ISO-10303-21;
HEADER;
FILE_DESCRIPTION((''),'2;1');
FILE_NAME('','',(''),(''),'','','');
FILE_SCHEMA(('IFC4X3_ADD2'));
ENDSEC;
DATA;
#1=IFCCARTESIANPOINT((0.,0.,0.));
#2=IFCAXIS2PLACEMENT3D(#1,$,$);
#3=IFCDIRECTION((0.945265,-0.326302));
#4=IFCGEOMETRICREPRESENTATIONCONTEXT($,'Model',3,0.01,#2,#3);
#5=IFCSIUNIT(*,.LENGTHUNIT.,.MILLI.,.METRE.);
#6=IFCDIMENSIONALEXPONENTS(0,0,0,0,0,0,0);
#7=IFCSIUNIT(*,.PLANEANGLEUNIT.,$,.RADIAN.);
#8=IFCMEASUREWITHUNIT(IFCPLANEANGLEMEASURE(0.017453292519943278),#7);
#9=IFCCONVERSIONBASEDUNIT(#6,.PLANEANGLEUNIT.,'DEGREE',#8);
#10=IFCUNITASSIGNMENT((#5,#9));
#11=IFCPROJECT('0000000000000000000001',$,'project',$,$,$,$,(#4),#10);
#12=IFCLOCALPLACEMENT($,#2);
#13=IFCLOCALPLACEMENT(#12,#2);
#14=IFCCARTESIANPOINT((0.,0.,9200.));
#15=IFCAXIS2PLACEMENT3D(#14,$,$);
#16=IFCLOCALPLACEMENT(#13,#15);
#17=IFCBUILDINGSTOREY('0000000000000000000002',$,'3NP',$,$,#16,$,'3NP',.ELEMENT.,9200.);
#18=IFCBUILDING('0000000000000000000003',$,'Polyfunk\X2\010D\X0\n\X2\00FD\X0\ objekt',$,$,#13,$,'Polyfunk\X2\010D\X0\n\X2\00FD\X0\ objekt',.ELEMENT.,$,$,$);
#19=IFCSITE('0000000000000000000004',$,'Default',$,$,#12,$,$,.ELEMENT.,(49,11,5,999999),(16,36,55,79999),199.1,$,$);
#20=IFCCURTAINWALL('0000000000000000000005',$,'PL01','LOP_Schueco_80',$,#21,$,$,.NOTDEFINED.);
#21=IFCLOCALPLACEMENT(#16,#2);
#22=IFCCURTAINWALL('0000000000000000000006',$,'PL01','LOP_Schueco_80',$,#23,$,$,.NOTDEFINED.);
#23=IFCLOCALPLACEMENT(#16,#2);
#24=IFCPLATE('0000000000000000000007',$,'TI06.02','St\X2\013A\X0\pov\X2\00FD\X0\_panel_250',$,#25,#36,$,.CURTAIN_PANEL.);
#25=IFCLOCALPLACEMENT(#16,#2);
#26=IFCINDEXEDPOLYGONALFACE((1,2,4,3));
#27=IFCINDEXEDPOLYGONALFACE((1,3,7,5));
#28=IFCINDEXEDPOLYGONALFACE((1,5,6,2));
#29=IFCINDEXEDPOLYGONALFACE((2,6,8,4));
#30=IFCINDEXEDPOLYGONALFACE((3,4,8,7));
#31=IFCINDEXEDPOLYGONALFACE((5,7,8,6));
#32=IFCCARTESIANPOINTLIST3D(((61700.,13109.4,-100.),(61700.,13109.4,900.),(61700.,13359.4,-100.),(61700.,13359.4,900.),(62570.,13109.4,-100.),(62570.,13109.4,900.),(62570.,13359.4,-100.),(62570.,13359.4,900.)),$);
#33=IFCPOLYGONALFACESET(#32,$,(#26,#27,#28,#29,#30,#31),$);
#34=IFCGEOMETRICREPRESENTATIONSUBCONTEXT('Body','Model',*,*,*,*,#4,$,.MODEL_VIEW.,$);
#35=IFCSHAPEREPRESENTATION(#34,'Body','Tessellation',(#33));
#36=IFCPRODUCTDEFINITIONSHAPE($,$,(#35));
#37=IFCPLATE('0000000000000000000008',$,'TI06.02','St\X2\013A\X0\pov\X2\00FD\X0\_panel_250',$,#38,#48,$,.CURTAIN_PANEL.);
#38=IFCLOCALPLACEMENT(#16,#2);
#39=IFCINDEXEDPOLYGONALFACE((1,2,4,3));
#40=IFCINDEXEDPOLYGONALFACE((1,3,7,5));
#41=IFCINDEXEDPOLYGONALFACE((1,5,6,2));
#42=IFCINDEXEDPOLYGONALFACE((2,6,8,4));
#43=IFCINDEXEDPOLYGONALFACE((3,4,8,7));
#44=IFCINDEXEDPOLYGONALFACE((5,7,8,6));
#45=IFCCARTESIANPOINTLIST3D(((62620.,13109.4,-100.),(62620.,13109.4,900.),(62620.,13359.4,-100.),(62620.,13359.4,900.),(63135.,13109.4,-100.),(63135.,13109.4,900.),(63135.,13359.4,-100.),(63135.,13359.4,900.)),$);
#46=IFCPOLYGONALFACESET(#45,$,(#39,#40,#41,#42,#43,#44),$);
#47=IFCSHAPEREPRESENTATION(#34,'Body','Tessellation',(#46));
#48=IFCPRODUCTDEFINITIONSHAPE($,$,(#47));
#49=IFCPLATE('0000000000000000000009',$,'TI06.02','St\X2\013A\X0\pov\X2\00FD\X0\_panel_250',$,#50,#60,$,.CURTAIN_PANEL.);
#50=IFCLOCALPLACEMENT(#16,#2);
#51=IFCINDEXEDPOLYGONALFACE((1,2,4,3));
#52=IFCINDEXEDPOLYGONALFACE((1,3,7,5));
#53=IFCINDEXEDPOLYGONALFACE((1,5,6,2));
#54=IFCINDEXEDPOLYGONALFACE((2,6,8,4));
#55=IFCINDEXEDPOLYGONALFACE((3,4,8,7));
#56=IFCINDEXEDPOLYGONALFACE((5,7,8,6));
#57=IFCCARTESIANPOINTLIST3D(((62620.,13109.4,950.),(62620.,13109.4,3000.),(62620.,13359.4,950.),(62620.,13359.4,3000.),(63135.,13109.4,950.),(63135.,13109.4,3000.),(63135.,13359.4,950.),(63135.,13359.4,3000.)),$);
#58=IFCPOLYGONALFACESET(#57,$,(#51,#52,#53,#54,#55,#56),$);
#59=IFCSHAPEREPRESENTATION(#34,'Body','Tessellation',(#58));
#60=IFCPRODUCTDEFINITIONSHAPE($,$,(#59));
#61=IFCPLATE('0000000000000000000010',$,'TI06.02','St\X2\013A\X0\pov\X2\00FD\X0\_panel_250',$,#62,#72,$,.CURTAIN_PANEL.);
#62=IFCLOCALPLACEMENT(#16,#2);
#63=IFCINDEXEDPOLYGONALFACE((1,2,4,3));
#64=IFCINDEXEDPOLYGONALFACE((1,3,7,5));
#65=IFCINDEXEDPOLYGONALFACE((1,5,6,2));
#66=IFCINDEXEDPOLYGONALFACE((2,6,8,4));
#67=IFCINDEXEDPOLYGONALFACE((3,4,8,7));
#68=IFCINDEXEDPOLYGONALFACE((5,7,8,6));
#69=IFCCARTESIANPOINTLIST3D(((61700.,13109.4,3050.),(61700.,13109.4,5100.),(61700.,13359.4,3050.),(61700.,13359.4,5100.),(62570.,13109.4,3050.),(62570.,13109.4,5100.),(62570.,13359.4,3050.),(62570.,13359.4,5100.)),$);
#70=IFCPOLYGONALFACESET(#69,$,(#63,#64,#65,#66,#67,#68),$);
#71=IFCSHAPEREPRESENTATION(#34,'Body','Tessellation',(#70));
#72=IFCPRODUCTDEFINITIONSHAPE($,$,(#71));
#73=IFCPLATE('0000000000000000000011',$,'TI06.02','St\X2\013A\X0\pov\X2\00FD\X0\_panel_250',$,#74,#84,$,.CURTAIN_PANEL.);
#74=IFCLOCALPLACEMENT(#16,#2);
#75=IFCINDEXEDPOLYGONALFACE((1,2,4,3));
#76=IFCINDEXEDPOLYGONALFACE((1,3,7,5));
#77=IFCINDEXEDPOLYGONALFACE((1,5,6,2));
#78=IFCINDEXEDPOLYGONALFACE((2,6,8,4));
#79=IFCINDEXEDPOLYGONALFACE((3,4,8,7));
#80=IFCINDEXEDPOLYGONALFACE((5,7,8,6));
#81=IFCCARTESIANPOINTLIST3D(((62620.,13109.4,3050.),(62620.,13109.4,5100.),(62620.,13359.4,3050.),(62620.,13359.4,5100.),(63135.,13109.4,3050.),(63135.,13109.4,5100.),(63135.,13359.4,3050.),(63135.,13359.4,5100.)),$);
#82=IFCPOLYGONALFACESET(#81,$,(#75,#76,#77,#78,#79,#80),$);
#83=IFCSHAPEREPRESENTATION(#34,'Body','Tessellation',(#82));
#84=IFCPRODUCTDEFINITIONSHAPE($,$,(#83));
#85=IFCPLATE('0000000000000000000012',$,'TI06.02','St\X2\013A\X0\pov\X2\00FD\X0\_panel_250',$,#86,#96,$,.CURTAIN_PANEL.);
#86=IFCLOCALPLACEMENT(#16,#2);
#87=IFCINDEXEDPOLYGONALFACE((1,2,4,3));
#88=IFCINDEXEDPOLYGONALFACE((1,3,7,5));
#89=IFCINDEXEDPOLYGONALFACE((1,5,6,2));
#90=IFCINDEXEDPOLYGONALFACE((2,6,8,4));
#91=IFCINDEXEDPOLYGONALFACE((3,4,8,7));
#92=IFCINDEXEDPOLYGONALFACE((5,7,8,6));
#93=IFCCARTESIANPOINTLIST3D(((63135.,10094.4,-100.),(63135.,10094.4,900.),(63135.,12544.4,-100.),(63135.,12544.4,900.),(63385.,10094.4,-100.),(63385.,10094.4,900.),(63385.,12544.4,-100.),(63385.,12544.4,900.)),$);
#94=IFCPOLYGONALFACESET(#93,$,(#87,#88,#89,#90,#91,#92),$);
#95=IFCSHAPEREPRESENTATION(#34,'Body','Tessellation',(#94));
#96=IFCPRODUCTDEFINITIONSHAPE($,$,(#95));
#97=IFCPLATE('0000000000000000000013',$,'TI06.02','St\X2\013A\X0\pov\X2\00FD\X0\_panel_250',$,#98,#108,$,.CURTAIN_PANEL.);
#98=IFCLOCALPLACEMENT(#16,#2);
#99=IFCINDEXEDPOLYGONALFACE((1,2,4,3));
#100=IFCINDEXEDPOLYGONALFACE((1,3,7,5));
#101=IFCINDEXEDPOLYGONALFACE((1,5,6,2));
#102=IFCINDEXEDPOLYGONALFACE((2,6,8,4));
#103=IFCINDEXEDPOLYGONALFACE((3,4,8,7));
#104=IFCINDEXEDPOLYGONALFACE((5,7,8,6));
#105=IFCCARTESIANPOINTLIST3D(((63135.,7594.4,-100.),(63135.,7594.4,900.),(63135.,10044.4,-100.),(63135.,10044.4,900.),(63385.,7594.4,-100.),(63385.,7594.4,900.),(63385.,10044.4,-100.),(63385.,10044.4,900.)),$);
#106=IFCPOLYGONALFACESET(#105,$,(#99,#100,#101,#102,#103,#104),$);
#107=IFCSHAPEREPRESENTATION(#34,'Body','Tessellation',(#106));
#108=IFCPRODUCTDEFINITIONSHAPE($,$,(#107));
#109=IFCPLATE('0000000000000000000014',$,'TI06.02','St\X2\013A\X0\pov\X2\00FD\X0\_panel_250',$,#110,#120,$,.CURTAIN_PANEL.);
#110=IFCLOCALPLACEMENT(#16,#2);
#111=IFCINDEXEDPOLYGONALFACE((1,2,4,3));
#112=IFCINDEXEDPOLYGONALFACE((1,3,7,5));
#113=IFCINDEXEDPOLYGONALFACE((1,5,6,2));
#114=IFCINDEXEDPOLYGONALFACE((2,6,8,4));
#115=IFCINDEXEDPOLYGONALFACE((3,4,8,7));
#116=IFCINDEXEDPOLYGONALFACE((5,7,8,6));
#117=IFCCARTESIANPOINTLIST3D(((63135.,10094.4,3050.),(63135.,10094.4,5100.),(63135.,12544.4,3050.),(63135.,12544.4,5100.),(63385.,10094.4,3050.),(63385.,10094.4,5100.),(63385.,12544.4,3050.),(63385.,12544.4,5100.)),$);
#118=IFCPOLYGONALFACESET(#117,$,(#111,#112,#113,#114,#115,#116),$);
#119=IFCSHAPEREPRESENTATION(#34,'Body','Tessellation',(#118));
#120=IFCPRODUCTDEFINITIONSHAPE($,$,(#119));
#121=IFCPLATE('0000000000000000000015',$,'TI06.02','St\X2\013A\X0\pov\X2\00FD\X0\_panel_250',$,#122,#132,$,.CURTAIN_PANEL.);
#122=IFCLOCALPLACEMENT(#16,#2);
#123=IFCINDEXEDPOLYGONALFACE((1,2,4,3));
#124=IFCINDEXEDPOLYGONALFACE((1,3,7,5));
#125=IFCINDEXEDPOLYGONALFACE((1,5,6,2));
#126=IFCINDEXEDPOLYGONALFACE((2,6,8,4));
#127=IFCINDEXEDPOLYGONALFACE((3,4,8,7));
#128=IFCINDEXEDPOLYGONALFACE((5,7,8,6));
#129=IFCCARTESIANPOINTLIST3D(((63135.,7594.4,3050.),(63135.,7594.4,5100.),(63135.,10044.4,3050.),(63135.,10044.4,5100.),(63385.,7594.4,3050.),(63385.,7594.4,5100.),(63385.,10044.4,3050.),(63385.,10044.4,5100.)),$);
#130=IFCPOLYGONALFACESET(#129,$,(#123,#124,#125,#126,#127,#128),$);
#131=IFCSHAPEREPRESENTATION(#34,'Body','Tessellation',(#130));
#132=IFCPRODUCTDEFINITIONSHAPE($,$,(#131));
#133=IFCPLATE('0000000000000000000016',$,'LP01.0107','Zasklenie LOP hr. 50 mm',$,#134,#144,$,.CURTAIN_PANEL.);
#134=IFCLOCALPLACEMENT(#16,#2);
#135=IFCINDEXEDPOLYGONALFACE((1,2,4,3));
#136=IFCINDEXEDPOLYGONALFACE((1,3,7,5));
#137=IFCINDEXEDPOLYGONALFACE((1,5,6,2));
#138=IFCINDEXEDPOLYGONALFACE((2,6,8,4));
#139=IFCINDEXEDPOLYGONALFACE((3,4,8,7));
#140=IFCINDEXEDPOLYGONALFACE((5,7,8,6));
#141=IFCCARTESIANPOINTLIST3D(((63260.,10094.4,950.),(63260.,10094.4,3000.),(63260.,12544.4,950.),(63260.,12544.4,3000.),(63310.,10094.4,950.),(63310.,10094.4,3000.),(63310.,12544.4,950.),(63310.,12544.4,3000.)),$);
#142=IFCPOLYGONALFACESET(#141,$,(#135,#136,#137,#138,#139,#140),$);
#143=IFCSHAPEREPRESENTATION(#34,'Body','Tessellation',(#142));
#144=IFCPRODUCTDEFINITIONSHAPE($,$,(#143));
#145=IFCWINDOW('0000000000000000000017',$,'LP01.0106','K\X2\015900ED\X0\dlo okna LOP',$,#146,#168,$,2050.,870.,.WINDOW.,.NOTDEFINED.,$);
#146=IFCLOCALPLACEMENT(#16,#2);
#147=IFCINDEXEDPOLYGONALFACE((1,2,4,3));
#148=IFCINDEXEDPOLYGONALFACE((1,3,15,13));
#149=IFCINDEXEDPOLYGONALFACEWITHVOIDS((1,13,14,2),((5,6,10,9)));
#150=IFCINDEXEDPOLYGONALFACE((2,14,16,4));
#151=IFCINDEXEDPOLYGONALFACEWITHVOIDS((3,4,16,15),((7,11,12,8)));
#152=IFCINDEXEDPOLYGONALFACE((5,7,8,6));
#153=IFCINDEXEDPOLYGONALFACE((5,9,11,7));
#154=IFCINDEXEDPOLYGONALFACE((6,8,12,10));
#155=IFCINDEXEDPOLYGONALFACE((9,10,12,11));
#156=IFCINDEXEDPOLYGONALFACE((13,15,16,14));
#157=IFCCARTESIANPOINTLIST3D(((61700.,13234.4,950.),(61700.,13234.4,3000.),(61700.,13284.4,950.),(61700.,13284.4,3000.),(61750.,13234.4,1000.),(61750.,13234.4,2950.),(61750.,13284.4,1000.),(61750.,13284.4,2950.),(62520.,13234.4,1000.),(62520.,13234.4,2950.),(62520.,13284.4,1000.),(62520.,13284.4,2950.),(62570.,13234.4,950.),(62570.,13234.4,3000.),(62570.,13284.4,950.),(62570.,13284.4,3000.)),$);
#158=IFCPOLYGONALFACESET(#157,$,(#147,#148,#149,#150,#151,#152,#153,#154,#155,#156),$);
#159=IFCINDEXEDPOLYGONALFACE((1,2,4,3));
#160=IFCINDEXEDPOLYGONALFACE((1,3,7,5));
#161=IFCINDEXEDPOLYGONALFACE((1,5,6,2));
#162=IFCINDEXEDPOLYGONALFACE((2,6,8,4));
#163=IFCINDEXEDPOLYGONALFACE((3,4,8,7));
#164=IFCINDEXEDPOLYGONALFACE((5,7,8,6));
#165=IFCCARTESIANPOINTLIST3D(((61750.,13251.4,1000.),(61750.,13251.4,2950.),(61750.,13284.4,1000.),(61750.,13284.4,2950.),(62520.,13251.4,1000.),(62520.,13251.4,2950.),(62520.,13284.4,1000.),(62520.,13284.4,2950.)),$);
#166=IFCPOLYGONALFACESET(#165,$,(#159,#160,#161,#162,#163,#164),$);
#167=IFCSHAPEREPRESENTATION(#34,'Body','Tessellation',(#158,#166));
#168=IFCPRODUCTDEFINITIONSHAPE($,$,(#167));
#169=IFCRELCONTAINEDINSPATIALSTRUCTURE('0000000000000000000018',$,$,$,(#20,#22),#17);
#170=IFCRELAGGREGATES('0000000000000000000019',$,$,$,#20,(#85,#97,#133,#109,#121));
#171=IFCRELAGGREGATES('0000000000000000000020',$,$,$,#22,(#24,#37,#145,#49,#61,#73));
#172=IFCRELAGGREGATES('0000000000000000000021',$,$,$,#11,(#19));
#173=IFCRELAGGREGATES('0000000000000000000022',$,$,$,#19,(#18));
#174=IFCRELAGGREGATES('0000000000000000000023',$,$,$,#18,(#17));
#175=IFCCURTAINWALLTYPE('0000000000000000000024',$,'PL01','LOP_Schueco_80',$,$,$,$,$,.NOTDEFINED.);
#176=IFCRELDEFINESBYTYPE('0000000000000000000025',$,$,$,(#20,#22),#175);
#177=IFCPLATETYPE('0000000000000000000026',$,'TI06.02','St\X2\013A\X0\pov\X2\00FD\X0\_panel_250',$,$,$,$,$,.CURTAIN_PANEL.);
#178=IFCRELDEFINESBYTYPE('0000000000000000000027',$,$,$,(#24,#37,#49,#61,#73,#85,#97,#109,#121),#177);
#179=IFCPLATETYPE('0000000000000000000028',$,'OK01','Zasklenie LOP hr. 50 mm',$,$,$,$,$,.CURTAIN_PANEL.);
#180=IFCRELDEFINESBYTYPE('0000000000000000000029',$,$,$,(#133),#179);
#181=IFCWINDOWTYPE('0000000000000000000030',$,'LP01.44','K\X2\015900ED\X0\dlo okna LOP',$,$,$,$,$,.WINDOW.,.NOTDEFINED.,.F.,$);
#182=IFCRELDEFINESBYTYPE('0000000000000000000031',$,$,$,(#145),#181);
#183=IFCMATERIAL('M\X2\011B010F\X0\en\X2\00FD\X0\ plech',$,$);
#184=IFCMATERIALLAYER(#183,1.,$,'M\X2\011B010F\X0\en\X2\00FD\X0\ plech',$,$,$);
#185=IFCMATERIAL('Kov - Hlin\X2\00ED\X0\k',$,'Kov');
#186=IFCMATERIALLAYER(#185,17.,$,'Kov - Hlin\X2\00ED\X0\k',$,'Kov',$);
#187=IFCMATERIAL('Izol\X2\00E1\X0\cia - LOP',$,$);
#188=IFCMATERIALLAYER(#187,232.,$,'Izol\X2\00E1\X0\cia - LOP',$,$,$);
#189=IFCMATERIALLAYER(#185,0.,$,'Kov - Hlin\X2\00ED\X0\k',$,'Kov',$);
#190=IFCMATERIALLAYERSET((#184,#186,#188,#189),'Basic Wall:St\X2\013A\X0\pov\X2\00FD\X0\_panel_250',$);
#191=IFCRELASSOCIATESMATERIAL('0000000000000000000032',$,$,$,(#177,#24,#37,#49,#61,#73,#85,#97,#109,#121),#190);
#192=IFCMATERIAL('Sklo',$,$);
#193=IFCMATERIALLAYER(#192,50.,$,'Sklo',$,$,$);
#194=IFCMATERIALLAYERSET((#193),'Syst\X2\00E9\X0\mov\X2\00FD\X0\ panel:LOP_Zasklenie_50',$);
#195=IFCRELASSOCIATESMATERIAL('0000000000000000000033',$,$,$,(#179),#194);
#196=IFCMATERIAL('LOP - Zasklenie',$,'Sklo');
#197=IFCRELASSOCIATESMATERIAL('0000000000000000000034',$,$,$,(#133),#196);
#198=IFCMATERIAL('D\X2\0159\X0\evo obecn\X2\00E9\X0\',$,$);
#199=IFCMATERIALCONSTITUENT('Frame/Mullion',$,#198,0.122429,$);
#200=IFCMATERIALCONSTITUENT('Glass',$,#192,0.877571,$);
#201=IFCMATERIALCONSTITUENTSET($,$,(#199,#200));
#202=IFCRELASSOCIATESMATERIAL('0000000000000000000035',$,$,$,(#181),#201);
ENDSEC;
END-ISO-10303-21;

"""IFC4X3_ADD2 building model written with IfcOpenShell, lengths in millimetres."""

from ifc_helpers import new_model, entity, si_unit, converted_unit, direction, frame, frame_2d, origin, origin_2d_with_axis, place, context, subcontext, project, spatial, polyline, rectangle, outline, extrude, source, transform, mapped, material, layer, layer_set, layer_usage, constituent, constituent_set, type_object, type_shapes, element, aggregate, save


model = new_model("IFC4X3_ADD2")

# Units and contexts
model_context = context("Model", 3, precision=0.01, world=origin(), true_north=direction((0.945265, -0.326302)))
body_context = subcontext(model_context, "Body", "Model", "MODEL_VIEW")
ifc_project = project(units=[si_unit("LENGTHUNIT", "METRE", prefix="MILLI"), converted_unit("PLANEANGLEUNIT", "DEGREE", entity("IfcPlaneAngleMeasure", 0.017453292519943278), si_unit("PLANEANGLEUNIT", "RADIAN"), dimensions=[0, 0, 0, 0, 0, 0, 0])], contexts=[model_context])

# Site, building, storey
site_placement = place(None, origin())
site = spatial("IfcSite", under=ifc_project, at=site_placement, Name="Default", CompositionType="ELEMENT", RefLatitude=(49, 11, 5, 999999), RefLongitude=(16, 36, 55, 79999), RefElevation=199.1)
building_placement = place(site_placement, origin())
building = spatial("IfcBuilding", under=site, at=building_placement, Name="Polyfunkčný objekt", LongName="Polyfunkčný objekt", CompositionType="ELEMENT")
storey_placement = place(building_placement, frame((0.0, 0.0, 9200.0)))
storey = spatial("IfcBuildingStorey", under=building, at=storey_placement, Name="3NP", LongName="3NP", CompositionType="ELEMENT", Elevation=9200.0)

# Curtain walls
curtain_wall_type = type_object("IfcCurtainWallType", Name="PL01", Description="LOP_Schueco_80", PredefinedType="NOTDEFINED")
curtain_wall_1_placement = place(storey_placement, frame((0.0, 0.0, -9200.0)))
curtain_wall_1 = element("IfcCurtainWall", 1, at=curtain_wall_1_placement, inside=storey, type_object=curtain_wall_type, Name="PL01", Description="LOP_Schueco_80", PredefinedType="NOTDEFINED")
curtain_wall_2_placement = place(storey_placement, frame((0.0, 0.0, -9200.0)))
curtain_wall_2 = element("IfcCurtainWall", 2, at=curtain_wall_2_placement, inside=storey, type_object=curtain_wall_type, Name="PL01", Description="LOP_Schueco_80", PredefinedType="NOTDEFINED")

# Plates
ifc_material_1 = material(Name="Měďený plech")
ifc_layer_1 = layer(ifc_material_1, 1.0, Name="Měďený plech")
ifc_material_2 = material(Name="Kov - Hliník", Category="Kov")
ifc_layer_2 = layer(ifc_material_2, 17.0, Name="Kov - Hliník", Category="Kov")
ifc_material_3 = material(Name="Izolácia - LOP")
ifc_layer_3 = layer(ifc_material_3, 232.0, Name="Izolácia - LOP")
ifc_layer_4 = layer(ifc_material_2, 0.0, Name="Kov - Hliník", Category="Kov")
ifc_layer_set_1 = layer_set([ifc_layer_1, ifc_layer_2, ifc_layer_3, ifc_layer_4], Name="Basic Wall:Stĺpový_panel_250")
ifc_layer_usage_1 = layer_usage(ifc_layer_set_1, "AXIS2", "NEGATIVE", 125.0)
plate_type_1 = type_object("IfcPlateType", Name="TI06.02", Description="Stĺpový_panel_250", PredefinedType="CURTAIN_PANEL", material=ifc_layer_set_1)
plate_1_placement = place(storey_placement, frame((61700.0, 13234.4, -100.0)))
plate_1 = element("IfcPlate", 3, at=plate_1_placement, type_object=plate_type_1, material=ifc_layer_usage_1, Name="TI06.02", Description="Stĺpový_panel_250", PredefinedType="CURTAIN_PANEL", context=body_context, shape_type="SweptSolid", body=[
    extrude(rectangle(XDim=250.0, YDim=870.0, at=frame_2d((0.0, 0.0), x_axis=(1.0, 0.0))), frame((435.0, 0.0, 0.0), z_axis=(0.0, 0.0, 1.0), x_axis=(0.0, 1.0, 0.0)), (0.0, 0.0, 1.0), 1000.0),
])
ifc_layer_usage_2 = layer_usage(ifc_layer_set_1, "AXIS2", "NEGATIVE", 125.0)
plate_2_placement = place(storey_placement, frame((62620.0, 13234.4, -100.0)))
plate_2 = element("IfcPlate", 4, at=plate_2_placement, type_object=plate_type_1, material=ifc_layer_usage_2, Name="TI06.02", Description="Stĺpový_panel_250", PredefinedType="CURTAIN_PANEL", context=body_context, shape_type="SweptSolid", body=[
    extrude(rectangle(XDim=250.0, YDim=515.0, at=frame_2d((0.0, 0.0), x_axis=(1.0, 0.0))), frame((257.5, 0.0, 0.0), z_axis=(0.0, 0.0, 1.0), x_axis=(0.0, 1.0, 0.0)), (0.0, 0.0, 1.0), 1000.0),
])
ifc_layer_usage_3 = layer_usage(ifc_layer_set_1, "AXIS2", "NEGATIVE", 125.0)
plate_3_placement = place(storey_placement, frame((62620.0, 13234.4, 950.0)))
plate_3 = element("IfcPlate", 5, at=plate_3_placement, type_object=plate_type_1, material=ifc_layer_usage_3, Name="TI06.02", Description="Stĺpový_panel_250", PredefinedType="CURTAIN_PANEL", context=body_context, shape_type="SweptSolid", body=[
    extrude(rectangle(XDim=250.0, YDim=515.0, at=frame_2d((0.0, 0.0), x_axis=(1.0, 0.0))), frame((257.5, 0.0, 0.0), z_axis=(0.0, 0.0, 1.0), x_axis=(0.0, 1.0, 0.0)), (0.0, 0.0, 1.0), 2050.0),
])
ifc_layer_usage_4 = layer_usage(ifc_layer_set_1, "AXIS2", "NEGATIVE", 125.0)
plate_4_placement = place(storey_placement, frame((61700.0, 13234.4, 3050.0)))
plate_4 = element("IfcPlate", 6, at=plate_4_placement, type_object=plate_type_1, material=ifc_layer_usage_4, Name="TI06.02", Description="Stĺpový_panel_250", PredefinedType="CURTAIN_PANEL", context=body_context, shape_type="SweptSolid", body=[
    extrude(rectangle(XDim=250.0, YDim=870.0, at=frame_2d((0.0, 0.0), x_axis=(1.0, 0.0))), frame((435.0, 0.0, 0.0), z_axis=(0.0, 0.0, 1.0), x_axis=(0.0, 1.0, 0.0)), (0.0, 0.0, 1.0), 2050.0),
])
ifc_layer_usage_5 = layer_usage(ifc_layer_set_1, "AXIS2", "NEGATIVE", 125.0)
plate_5_placement = place(storey_placement, frame((62620.0, 13234.4, 3050.0)))
plate_5 = element("IfcPlate", 7, at=plate_5_placement, type_object=plate_type_1, material=ifc_layer_usage_5, Name="TI06.02", Description="Stĺpový_panel_250", PredefinedType="CURTAIN_PANEL", context=body_context, shape_type="SweptSolid", body=[
    extrude(rectangle(XDim=250.0, YDim=515.0, at=frame_2d((0.0, 0.0), x_axis=(1.0, 0.0))), frame((257.5, 0.0, 0.0), z_axis=(0.0, 0.0, 1.0), x_axis=(0.0, 1.0, 0.0)), (0.0, 0.0, 1.0), 2050.0),
])
ifc_layer_usage_6 = layer_usage(ifc_layer_set_1, "AXIS2", "NEGATIVE", 125.0)
plate_6_placement = place(storey_placement, frame((63260.0, 12544.4, -100.0), z_axis=(0.0, 0.0, 1.0), x_axis=(0.0, -1.0, 0.0)))
plate_6 = element("IfcPlate", 8, at=plate_6_placement, type_object=plate_type_1, material=ifc_layer_usage_6, Name="TI06.02", Description="Stĺpový_panel_250", PredefinedType="CURTAIN_PANEL", context=body_context, shape_type="SweptSolid", body=[
    extrude(rectangle(XDim=250.0, YDim=2450.0, at=frame_2d((0.0, 0.0), x_axis=(1.0, 0.0))), frame((1225.0, 0.0, 0.0), z_axis=(0.0, 0.0, 1.0), x_axis=(0.0, 1.0, 0.0)), (0.0, 0.0, 1.0), 1000.0),
])
ifc_layer_usage_7 = layer_usage(ifc_layer_set_1, "AXIS2", "NEGATIVE", 125.0)
plate_7_placement = place(storey_placement, frame((63260.0, 10044.4, -100.0), z_axis=(0.0, 0.0, 1.0), x_axis=(0.0, -1.0, 0.0)))
plate_7 = element("IfcPlate", 9, at=plate_7_placement, type_object=plate_type_1, material=ifc_layer_usage_7, Name="TI06.02", Description="Stĺpový_panel_250", PredefinedType="CURTAIN_PANEL", context=body_context, shape_type="SweptSolid", body=[
    extrude(rectangle(XDim=250.0, YDim=2450.0, at=origin_2d_with_axis()), frame((1225.0, 0.0, 0.0), z_axis=(0.0, 0.0, 1.0), x_axis=(0.0, 1.0, 0.0)), (0.0, 0.0, 1.0), 1000.0),
])
ifc_layer_usage_8 = layer_usage(ifc_layer_set_1, "AXIS2", "NEGATIVE", 125.0)
plate_8_placement = place(storey_placement, frame((63260.0, 12544.4, 3050.0), z_axis=(0.0, 0.0, 1.0), x_axis=(0.0, -1.0, 0.0)))
plate_8 = element("IfcPlate", 10, at=plate_8_placement, type_object=plate_type_1, material=ifc_layer_usage_8, Name="TI06.02", Description="Stĺpový_panel_250", PredefinedType="CURTAIN_PANEL", context=body_context, shape_type="SweptSolid", body=[
    extrude(rectangle(XDim=250.0, YDim=2450.0, at=frame_2d((0.0, 0.0), x_axis=(1.0, 0.0))), frame((1225.0, 0.0, 0.0), z_axis=(0.0, 0.0, 1.0), x_axis=(0.0, 1.0, 0.0)), (0.0, 0.0, 1.0), 2050.0),
])
ifc_layer_usage_9 = layer_usage(ifc_layer_set_1, "AXIS2", "NEGATIVE", 125.0)
plate_9_placement = place(storey_placement, frame((63260.0, 10044.4, 3050.0), z_axis=(0.0, 0.0, 1.0), x_axis=(0.0, -1.0, 0.0)))
plate_9 = element("IfcPlate", 11, at=plate_9_placement, type_object=plate_type_1, material=ifc_layer_usage_9, Name="TI06.02", Description="Stĺpový_panel_250", PredefinedType="CURTAIN_PANEL", context=body_context, shape_type="SweptSolid", body=[
    extrude(rectangle(XDim=250.0, YDim=2450.0, at=frame_2d((0.0, 0.0), x_axis=(1.0, 0.0))), frame((1225.0, 0.0, 0.0), z_axis=(0.0, 0.0, 1.0), x_axis=(0.0, 1.0, 0.0)), (0.0, 0.0, 1.0), 2050.0),
])
ifc_material_4 = material(Name="LOP - Zasklenie", Category="Sklo")
ifc_material_5 = material(Name="Sklo")
ifc_layer_5 = layer(ifc_material_5, 50.0, Name="Sklo")
ifc_layer_set_2 = layer_set([ifc_layer_5], Name="Systémový panel:LOP_Zasklenie_50")
plate_type_2 = type_object("IfcPlateType", Name="OK01", Description="Zasklenie LOP hr. 50 mm", PredefinedType="CURTAIN_PANEL", material=ifc_layer_set_2)
shared_shape_1 = source(origin(), body_context, "Body", "SweptSolid", [
    extrude(rectangle(XDim=50.0, YDim=2450.0, at=origin_2d_with_axis()), frame((0.0, 25.0, 0.0), z_axis=(0.0, 0.0, 1.0), x_axis=(0.0, 1.0, 0.0)), (0.0, 0.0, 1.0), 2050.0),
])
type_shapes(plate_type_2, [shared_shape_1])
plate_10_placement = place(curtain_wall_1_placement, frame((63260.0, 11319.4, 10150.0), z_axis=(0.0, 0.0, 1.0), x_axis=(0.0, -1.0, 0.0)))
plate_10 = element("IfcPlate", 12, at=plate_10_placement, type_object=plate_type_2, material=ifc_material_4, Name="LP01.0107", Description="Zasklenie LOP hr. 50 mm", PredefinedType="CURTAIN_PANEL", context=body_context, shape_type="MappedRepresentation", body=[
    mapped(shared_shape_1, transform((0.0, 0.0, 0.0), scale=1.0)),
])
aggregate(curtain_wall_1, [plate_6, plate_7, plate_10, plate_8, plate_9])

# Window
ifc_material_6 = material(Name="Dřevo obecné")
ifc_constituent_1 = constituent(ifc_material_6, Name="Frame/Mullion", fraction=0.122429)
ifc_constituent_2 = constituent(ifc_material_5, Name="Glass", fraction=0.877571)
ifc_constituent_set = constituent_set(constituents=[ifc_constituent_1, ifc_constituent_2])
window_type = type_object("IfcWindowType", Name="LP01.44", Description="Křídlo okna LOP", ParameterTakesPrecedence=False, PartitioningType="NOTDEFINED", PredefinedType="WINDOW", material=ifc_constituent_set)
shared_shape_2 = source(origin(), body_context, "Body", "SweptSolid", [
    extrude(outline(polyline([(-1025.0, -435.0), (1025.0, -435.0), (1025.0, 435.0), (-1025.0, 435.0), (-1025.0, -435.0)]), holes=[polyline([(-975.0, -385.0), (-975.0, 385.0), (975.0, 385.0), (975.0, -385.0), (-975.0, -385.0)])]), frame((0.0, 0.0, 1025.0), z_axis=(0.0, 1.0, 0.0), x_axis=(0.0, 0.0, -1.0)), (0.0, 0.0, 1.0), 50.0),
    extrude(rectangle(XDim=33.0, YDim=770.0, at=origin_2d_with_axis()), frame((0.0, 33.5, 50.0), z_axis=(0.0, 0.0, 1.0), x_axis=(0.0, -1.0, 0.0)), (0.0, 0.0, 1.0), 1950.0),
])
type_shapes(window_type, [shared_shape_2])
window_placement = place(curtain_wall_2_placement, frame((62135.0, 13234.4, 10150.0)))
window = element("IfcWindow", 13, at=window_placement, type_object=window_type, Name="LP01.0106", Description="Křídlo okna LOP", OverallHeight=2050.0, OverallWidth=870.0, PartitioningType="NOTDEFINED", PredefinedType="WINDOW", context=body_context, shape_type="MappedRepresentation", body=[
    mapped(shared_shape_2, transform((0.0, 0.0, 0.0), scale=1.0)),
])
aggregate(curtain_wall_2, [plate_1, plate_2, window, plate_3, plate_4, plate_5])

save(model, "model.ifc")
